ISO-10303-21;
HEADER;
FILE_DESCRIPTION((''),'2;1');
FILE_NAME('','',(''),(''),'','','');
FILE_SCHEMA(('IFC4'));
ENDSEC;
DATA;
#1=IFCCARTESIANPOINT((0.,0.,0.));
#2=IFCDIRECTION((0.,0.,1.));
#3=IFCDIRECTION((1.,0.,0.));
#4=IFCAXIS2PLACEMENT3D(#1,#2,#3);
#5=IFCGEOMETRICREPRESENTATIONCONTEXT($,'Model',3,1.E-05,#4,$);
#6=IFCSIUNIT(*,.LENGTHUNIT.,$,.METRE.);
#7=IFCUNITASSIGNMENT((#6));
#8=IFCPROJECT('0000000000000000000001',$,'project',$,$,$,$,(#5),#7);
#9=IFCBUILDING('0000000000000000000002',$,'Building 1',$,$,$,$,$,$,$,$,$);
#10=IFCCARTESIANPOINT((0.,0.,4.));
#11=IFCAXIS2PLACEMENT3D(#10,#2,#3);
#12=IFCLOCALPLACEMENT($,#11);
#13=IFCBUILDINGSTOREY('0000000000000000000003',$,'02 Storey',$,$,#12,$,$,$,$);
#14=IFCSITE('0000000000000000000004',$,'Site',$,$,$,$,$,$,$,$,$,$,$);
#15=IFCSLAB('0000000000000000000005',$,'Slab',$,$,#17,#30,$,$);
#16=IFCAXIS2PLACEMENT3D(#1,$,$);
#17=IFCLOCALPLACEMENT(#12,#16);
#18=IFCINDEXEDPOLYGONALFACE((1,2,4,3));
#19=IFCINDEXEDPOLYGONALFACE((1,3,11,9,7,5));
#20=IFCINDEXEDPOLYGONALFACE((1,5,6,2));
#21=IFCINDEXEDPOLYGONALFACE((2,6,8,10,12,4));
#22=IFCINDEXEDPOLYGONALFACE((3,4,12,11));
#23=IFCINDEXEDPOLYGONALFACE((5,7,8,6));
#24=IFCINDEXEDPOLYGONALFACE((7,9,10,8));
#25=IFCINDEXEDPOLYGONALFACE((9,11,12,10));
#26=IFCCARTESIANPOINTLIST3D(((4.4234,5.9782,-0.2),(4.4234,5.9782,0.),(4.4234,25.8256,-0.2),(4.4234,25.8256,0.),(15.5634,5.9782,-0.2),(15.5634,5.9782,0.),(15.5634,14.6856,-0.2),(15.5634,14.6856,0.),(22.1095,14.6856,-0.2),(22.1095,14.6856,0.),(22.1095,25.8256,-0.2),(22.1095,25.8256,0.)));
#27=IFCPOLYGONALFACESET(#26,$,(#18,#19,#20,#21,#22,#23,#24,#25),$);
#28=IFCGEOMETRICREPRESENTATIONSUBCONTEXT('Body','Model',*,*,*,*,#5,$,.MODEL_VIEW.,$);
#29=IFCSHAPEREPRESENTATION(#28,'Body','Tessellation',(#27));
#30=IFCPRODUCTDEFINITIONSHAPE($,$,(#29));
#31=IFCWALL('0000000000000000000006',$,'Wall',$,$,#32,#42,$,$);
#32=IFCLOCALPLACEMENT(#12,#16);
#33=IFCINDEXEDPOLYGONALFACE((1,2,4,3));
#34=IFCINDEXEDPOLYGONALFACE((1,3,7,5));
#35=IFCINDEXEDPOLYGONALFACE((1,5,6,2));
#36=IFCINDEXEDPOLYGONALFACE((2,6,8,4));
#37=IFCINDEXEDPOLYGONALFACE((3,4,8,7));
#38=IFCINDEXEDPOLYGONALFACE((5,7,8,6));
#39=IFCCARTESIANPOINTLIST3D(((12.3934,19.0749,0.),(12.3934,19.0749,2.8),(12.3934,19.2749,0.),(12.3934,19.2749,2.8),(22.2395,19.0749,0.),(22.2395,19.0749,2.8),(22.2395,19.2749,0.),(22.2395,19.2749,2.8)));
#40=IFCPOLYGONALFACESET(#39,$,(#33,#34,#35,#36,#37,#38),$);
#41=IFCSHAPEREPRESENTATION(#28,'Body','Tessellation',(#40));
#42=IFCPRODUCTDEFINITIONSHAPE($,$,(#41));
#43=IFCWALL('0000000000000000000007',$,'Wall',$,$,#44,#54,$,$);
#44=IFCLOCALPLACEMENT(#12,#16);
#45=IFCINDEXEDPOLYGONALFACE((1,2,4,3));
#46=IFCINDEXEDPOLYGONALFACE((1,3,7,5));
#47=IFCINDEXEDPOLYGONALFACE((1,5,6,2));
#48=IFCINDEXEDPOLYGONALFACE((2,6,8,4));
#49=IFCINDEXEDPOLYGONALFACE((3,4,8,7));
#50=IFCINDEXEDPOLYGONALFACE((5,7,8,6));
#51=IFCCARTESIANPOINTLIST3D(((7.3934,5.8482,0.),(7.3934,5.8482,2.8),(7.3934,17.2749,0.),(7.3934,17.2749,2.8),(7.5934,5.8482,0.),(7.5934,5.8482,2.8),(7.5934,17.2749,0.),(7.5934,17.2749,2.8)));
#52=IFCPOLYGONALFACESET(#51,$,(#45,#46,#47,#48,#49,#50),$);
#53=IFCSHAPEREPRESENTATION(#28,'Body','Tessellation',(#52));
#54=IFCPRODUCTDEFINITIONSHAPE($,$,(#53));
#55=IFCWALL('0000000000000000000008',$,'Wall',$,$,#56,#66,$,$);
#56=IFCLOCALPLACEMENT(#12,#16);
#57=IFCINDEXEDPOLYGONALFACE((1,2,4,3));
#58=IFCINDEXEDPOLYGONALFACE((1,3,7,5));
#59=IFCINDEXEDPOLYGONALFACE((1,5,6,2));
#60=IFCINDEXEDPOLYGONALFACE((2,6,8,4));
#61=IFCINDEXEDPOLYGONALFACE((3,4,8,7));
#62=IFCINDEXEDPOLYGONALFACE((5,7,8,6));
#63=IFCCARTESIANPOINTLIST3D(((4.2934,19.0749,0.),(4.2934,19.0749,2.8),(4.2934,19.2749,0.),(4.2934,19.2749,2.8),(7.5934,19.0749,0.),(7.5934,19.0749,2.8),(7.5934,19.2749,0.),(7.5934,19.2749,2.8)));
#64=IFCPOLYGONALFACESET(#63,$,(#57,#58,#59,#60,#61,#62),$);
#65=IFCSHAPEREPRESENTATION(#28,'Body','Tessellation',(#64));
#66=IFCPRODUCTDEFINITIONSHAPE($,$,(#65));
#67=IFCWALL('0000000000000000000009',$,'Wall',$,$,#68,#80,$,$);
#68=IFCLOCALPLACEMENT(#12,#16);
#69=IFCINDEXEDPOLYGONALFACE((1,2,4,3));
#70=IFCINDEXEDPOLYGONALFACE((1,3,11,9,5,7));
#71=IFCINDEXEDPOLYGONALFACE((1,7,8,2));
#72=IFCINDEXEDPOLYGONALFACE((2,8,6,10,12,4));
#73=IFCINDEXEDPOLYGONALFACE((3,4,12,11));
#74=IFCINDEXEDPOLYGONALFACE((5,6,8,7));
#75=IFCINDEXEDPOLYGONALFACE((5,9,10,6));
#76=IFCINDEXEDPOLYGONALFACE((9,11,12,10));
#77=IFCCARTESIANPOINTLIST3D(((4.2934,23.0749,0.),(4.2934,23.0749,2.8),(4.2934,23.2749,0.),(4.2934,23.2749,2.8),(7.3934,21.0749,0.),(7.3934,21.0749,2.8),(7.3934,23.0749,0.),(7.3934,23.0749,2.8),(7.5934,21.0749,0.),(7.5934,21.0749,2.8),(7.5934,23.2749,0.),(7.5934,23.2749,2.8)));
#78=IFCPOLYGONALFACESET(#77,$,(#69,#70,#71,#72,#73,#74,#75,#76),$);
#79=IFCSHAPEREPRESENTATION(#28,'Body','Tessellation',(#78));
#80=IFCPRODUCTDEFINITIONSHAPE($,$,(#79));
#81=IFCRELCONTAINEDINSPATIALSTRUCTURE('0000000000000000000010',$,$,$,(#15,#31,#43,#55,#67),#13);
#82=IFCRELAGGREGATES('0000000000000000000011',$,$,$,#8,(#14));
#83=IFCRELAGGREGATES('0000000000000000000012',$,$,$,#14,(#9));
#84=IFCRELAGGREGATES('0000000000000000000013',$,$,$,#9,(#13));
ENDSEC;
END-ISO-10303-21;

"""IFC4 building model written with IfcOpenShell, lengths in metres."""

from ifc_helpers import new_model, si_unit, frame, origin_with_axes, place, context, subcontext, project, spatial, line, indexed_curve, outline, extrude, element, save


model = new_model("IFC4")

# Units and contexts
model_context = context("Model", 3, precision=1e-05, world=origin_with_axes())
body_context = subcontext(model_context, "Body", "Model", "MODEL_VIEW")
ifc_project = project(units=[si_unit("LENGTHUNIT", "METRE")], contexts=[model_context])

# Site, building, storey
site = spatial("IfcSite", under=ifc_project, Name="Site")
building = spatial("IfcBuilding", under=site, Name="Building 1")
storey_placement = place(None, frame((0.0, 0.0, 4.0), z_axis=(0.0, 0.0, 1.0), x_axis=(1.0, 0.0, 0.0)))
storey = spatial("IfcBuildingStorey", under=building, at=storey_placement, Name="02 Storey")

# Slab
slab_placement = place(storey_placement, origin_with_axes())
element("IfcSlab", 1, at=slab_placement, inside=storey, Name="Slab", context=body_context, shape_type="SweptSolid", body=[
    extrude(outline(indexed_curve([(15.5634, 14.6856), (22.1095, 14.6856), (22.1095, 25.8256), (4.4234, 25.8256), (4.4234, 5.9782), (15.5634, 5.9782)], segments=[line(1, 2), line(2, 3), line(3, 4), line(4, 5), line(5, 6)])), origin_with_axes(), (0.0, 0.0, -1.0), 0.2),
])

# Walls
wall_1_placement = place(storey_placement, origin_with_axes())
element("IfcWall", 2, at=wall_1_placement, inside=storey, Name="Wall", context=body_context, shape_type="SweptSolid", body=[
    extrude(outline(indexed_curve([(22.2395, 19.2749), (12.3934, 19.2749), (12.3934, 19.0749), (22.2395, 19.0749)], segments=[line(1, 2), line(2, 3), line(3, 4)])), origin_with_axes(), (0.0, 0.0, 1.0), 2.8),
])
wall_2_placement = place(storey_placement, origin_with_axes())
element("IfcWall", 3, at=wall_2_placement, inside=storey, Name="Wall", context=body_context, shape_type="SweptSolid", body=[
    extrude(outline(indexed_curve([(7.5934, 17.2749), (7.3934, 17.2749), (7.3934, 5.8482), (7.5934, 5.8482)], segments=[line(1, 2), line(2, 3), line(3, 4)])), origin_with_axes(), (0.0, 0.0, 1.0), 2.8),
])
wall_3_placement = place(storey_placement, origin_with_axes())
element("IfcWall", 4, at=wall_3_placement, inside=storey, Name="Wall", context=body_context, shape_type="SweptSolid", body=[
    extrude(outline(indexed_curve([(7.5934, 19.2749), (4.2934, 19.2749), (4.2934, 19.0749), (7.5934, 19.0749)], segments=[line(1, 2), line(2, 3), line(3, 4)])), origin_with_axes(), (0.0, 0.0, 1.0), 2.8),
])
wall_4_placement = place(storey_placement, origin_with_axes())
element("IfcWall", 5, at=wall_4_placement, inside=storey, Name="Wall", context=body_context, shape_type="SweptSolid", body=[
    extrude(outline(indexed_curve([(7.5934, 23.2749), (4.2934, 23.2749), (4.2934, 23.0749), (7.3934, 23.0749), (7.3934, 21.0749), (7.5934, 21.0749)], segments=[line(1, 2), line(2, 3), line(3, 4), line(4, 5), line(5, 6)])), origin_with_axes(), (0.0, 0.0, 1.0), 2.8),
])

save(model, "model.ifc")
